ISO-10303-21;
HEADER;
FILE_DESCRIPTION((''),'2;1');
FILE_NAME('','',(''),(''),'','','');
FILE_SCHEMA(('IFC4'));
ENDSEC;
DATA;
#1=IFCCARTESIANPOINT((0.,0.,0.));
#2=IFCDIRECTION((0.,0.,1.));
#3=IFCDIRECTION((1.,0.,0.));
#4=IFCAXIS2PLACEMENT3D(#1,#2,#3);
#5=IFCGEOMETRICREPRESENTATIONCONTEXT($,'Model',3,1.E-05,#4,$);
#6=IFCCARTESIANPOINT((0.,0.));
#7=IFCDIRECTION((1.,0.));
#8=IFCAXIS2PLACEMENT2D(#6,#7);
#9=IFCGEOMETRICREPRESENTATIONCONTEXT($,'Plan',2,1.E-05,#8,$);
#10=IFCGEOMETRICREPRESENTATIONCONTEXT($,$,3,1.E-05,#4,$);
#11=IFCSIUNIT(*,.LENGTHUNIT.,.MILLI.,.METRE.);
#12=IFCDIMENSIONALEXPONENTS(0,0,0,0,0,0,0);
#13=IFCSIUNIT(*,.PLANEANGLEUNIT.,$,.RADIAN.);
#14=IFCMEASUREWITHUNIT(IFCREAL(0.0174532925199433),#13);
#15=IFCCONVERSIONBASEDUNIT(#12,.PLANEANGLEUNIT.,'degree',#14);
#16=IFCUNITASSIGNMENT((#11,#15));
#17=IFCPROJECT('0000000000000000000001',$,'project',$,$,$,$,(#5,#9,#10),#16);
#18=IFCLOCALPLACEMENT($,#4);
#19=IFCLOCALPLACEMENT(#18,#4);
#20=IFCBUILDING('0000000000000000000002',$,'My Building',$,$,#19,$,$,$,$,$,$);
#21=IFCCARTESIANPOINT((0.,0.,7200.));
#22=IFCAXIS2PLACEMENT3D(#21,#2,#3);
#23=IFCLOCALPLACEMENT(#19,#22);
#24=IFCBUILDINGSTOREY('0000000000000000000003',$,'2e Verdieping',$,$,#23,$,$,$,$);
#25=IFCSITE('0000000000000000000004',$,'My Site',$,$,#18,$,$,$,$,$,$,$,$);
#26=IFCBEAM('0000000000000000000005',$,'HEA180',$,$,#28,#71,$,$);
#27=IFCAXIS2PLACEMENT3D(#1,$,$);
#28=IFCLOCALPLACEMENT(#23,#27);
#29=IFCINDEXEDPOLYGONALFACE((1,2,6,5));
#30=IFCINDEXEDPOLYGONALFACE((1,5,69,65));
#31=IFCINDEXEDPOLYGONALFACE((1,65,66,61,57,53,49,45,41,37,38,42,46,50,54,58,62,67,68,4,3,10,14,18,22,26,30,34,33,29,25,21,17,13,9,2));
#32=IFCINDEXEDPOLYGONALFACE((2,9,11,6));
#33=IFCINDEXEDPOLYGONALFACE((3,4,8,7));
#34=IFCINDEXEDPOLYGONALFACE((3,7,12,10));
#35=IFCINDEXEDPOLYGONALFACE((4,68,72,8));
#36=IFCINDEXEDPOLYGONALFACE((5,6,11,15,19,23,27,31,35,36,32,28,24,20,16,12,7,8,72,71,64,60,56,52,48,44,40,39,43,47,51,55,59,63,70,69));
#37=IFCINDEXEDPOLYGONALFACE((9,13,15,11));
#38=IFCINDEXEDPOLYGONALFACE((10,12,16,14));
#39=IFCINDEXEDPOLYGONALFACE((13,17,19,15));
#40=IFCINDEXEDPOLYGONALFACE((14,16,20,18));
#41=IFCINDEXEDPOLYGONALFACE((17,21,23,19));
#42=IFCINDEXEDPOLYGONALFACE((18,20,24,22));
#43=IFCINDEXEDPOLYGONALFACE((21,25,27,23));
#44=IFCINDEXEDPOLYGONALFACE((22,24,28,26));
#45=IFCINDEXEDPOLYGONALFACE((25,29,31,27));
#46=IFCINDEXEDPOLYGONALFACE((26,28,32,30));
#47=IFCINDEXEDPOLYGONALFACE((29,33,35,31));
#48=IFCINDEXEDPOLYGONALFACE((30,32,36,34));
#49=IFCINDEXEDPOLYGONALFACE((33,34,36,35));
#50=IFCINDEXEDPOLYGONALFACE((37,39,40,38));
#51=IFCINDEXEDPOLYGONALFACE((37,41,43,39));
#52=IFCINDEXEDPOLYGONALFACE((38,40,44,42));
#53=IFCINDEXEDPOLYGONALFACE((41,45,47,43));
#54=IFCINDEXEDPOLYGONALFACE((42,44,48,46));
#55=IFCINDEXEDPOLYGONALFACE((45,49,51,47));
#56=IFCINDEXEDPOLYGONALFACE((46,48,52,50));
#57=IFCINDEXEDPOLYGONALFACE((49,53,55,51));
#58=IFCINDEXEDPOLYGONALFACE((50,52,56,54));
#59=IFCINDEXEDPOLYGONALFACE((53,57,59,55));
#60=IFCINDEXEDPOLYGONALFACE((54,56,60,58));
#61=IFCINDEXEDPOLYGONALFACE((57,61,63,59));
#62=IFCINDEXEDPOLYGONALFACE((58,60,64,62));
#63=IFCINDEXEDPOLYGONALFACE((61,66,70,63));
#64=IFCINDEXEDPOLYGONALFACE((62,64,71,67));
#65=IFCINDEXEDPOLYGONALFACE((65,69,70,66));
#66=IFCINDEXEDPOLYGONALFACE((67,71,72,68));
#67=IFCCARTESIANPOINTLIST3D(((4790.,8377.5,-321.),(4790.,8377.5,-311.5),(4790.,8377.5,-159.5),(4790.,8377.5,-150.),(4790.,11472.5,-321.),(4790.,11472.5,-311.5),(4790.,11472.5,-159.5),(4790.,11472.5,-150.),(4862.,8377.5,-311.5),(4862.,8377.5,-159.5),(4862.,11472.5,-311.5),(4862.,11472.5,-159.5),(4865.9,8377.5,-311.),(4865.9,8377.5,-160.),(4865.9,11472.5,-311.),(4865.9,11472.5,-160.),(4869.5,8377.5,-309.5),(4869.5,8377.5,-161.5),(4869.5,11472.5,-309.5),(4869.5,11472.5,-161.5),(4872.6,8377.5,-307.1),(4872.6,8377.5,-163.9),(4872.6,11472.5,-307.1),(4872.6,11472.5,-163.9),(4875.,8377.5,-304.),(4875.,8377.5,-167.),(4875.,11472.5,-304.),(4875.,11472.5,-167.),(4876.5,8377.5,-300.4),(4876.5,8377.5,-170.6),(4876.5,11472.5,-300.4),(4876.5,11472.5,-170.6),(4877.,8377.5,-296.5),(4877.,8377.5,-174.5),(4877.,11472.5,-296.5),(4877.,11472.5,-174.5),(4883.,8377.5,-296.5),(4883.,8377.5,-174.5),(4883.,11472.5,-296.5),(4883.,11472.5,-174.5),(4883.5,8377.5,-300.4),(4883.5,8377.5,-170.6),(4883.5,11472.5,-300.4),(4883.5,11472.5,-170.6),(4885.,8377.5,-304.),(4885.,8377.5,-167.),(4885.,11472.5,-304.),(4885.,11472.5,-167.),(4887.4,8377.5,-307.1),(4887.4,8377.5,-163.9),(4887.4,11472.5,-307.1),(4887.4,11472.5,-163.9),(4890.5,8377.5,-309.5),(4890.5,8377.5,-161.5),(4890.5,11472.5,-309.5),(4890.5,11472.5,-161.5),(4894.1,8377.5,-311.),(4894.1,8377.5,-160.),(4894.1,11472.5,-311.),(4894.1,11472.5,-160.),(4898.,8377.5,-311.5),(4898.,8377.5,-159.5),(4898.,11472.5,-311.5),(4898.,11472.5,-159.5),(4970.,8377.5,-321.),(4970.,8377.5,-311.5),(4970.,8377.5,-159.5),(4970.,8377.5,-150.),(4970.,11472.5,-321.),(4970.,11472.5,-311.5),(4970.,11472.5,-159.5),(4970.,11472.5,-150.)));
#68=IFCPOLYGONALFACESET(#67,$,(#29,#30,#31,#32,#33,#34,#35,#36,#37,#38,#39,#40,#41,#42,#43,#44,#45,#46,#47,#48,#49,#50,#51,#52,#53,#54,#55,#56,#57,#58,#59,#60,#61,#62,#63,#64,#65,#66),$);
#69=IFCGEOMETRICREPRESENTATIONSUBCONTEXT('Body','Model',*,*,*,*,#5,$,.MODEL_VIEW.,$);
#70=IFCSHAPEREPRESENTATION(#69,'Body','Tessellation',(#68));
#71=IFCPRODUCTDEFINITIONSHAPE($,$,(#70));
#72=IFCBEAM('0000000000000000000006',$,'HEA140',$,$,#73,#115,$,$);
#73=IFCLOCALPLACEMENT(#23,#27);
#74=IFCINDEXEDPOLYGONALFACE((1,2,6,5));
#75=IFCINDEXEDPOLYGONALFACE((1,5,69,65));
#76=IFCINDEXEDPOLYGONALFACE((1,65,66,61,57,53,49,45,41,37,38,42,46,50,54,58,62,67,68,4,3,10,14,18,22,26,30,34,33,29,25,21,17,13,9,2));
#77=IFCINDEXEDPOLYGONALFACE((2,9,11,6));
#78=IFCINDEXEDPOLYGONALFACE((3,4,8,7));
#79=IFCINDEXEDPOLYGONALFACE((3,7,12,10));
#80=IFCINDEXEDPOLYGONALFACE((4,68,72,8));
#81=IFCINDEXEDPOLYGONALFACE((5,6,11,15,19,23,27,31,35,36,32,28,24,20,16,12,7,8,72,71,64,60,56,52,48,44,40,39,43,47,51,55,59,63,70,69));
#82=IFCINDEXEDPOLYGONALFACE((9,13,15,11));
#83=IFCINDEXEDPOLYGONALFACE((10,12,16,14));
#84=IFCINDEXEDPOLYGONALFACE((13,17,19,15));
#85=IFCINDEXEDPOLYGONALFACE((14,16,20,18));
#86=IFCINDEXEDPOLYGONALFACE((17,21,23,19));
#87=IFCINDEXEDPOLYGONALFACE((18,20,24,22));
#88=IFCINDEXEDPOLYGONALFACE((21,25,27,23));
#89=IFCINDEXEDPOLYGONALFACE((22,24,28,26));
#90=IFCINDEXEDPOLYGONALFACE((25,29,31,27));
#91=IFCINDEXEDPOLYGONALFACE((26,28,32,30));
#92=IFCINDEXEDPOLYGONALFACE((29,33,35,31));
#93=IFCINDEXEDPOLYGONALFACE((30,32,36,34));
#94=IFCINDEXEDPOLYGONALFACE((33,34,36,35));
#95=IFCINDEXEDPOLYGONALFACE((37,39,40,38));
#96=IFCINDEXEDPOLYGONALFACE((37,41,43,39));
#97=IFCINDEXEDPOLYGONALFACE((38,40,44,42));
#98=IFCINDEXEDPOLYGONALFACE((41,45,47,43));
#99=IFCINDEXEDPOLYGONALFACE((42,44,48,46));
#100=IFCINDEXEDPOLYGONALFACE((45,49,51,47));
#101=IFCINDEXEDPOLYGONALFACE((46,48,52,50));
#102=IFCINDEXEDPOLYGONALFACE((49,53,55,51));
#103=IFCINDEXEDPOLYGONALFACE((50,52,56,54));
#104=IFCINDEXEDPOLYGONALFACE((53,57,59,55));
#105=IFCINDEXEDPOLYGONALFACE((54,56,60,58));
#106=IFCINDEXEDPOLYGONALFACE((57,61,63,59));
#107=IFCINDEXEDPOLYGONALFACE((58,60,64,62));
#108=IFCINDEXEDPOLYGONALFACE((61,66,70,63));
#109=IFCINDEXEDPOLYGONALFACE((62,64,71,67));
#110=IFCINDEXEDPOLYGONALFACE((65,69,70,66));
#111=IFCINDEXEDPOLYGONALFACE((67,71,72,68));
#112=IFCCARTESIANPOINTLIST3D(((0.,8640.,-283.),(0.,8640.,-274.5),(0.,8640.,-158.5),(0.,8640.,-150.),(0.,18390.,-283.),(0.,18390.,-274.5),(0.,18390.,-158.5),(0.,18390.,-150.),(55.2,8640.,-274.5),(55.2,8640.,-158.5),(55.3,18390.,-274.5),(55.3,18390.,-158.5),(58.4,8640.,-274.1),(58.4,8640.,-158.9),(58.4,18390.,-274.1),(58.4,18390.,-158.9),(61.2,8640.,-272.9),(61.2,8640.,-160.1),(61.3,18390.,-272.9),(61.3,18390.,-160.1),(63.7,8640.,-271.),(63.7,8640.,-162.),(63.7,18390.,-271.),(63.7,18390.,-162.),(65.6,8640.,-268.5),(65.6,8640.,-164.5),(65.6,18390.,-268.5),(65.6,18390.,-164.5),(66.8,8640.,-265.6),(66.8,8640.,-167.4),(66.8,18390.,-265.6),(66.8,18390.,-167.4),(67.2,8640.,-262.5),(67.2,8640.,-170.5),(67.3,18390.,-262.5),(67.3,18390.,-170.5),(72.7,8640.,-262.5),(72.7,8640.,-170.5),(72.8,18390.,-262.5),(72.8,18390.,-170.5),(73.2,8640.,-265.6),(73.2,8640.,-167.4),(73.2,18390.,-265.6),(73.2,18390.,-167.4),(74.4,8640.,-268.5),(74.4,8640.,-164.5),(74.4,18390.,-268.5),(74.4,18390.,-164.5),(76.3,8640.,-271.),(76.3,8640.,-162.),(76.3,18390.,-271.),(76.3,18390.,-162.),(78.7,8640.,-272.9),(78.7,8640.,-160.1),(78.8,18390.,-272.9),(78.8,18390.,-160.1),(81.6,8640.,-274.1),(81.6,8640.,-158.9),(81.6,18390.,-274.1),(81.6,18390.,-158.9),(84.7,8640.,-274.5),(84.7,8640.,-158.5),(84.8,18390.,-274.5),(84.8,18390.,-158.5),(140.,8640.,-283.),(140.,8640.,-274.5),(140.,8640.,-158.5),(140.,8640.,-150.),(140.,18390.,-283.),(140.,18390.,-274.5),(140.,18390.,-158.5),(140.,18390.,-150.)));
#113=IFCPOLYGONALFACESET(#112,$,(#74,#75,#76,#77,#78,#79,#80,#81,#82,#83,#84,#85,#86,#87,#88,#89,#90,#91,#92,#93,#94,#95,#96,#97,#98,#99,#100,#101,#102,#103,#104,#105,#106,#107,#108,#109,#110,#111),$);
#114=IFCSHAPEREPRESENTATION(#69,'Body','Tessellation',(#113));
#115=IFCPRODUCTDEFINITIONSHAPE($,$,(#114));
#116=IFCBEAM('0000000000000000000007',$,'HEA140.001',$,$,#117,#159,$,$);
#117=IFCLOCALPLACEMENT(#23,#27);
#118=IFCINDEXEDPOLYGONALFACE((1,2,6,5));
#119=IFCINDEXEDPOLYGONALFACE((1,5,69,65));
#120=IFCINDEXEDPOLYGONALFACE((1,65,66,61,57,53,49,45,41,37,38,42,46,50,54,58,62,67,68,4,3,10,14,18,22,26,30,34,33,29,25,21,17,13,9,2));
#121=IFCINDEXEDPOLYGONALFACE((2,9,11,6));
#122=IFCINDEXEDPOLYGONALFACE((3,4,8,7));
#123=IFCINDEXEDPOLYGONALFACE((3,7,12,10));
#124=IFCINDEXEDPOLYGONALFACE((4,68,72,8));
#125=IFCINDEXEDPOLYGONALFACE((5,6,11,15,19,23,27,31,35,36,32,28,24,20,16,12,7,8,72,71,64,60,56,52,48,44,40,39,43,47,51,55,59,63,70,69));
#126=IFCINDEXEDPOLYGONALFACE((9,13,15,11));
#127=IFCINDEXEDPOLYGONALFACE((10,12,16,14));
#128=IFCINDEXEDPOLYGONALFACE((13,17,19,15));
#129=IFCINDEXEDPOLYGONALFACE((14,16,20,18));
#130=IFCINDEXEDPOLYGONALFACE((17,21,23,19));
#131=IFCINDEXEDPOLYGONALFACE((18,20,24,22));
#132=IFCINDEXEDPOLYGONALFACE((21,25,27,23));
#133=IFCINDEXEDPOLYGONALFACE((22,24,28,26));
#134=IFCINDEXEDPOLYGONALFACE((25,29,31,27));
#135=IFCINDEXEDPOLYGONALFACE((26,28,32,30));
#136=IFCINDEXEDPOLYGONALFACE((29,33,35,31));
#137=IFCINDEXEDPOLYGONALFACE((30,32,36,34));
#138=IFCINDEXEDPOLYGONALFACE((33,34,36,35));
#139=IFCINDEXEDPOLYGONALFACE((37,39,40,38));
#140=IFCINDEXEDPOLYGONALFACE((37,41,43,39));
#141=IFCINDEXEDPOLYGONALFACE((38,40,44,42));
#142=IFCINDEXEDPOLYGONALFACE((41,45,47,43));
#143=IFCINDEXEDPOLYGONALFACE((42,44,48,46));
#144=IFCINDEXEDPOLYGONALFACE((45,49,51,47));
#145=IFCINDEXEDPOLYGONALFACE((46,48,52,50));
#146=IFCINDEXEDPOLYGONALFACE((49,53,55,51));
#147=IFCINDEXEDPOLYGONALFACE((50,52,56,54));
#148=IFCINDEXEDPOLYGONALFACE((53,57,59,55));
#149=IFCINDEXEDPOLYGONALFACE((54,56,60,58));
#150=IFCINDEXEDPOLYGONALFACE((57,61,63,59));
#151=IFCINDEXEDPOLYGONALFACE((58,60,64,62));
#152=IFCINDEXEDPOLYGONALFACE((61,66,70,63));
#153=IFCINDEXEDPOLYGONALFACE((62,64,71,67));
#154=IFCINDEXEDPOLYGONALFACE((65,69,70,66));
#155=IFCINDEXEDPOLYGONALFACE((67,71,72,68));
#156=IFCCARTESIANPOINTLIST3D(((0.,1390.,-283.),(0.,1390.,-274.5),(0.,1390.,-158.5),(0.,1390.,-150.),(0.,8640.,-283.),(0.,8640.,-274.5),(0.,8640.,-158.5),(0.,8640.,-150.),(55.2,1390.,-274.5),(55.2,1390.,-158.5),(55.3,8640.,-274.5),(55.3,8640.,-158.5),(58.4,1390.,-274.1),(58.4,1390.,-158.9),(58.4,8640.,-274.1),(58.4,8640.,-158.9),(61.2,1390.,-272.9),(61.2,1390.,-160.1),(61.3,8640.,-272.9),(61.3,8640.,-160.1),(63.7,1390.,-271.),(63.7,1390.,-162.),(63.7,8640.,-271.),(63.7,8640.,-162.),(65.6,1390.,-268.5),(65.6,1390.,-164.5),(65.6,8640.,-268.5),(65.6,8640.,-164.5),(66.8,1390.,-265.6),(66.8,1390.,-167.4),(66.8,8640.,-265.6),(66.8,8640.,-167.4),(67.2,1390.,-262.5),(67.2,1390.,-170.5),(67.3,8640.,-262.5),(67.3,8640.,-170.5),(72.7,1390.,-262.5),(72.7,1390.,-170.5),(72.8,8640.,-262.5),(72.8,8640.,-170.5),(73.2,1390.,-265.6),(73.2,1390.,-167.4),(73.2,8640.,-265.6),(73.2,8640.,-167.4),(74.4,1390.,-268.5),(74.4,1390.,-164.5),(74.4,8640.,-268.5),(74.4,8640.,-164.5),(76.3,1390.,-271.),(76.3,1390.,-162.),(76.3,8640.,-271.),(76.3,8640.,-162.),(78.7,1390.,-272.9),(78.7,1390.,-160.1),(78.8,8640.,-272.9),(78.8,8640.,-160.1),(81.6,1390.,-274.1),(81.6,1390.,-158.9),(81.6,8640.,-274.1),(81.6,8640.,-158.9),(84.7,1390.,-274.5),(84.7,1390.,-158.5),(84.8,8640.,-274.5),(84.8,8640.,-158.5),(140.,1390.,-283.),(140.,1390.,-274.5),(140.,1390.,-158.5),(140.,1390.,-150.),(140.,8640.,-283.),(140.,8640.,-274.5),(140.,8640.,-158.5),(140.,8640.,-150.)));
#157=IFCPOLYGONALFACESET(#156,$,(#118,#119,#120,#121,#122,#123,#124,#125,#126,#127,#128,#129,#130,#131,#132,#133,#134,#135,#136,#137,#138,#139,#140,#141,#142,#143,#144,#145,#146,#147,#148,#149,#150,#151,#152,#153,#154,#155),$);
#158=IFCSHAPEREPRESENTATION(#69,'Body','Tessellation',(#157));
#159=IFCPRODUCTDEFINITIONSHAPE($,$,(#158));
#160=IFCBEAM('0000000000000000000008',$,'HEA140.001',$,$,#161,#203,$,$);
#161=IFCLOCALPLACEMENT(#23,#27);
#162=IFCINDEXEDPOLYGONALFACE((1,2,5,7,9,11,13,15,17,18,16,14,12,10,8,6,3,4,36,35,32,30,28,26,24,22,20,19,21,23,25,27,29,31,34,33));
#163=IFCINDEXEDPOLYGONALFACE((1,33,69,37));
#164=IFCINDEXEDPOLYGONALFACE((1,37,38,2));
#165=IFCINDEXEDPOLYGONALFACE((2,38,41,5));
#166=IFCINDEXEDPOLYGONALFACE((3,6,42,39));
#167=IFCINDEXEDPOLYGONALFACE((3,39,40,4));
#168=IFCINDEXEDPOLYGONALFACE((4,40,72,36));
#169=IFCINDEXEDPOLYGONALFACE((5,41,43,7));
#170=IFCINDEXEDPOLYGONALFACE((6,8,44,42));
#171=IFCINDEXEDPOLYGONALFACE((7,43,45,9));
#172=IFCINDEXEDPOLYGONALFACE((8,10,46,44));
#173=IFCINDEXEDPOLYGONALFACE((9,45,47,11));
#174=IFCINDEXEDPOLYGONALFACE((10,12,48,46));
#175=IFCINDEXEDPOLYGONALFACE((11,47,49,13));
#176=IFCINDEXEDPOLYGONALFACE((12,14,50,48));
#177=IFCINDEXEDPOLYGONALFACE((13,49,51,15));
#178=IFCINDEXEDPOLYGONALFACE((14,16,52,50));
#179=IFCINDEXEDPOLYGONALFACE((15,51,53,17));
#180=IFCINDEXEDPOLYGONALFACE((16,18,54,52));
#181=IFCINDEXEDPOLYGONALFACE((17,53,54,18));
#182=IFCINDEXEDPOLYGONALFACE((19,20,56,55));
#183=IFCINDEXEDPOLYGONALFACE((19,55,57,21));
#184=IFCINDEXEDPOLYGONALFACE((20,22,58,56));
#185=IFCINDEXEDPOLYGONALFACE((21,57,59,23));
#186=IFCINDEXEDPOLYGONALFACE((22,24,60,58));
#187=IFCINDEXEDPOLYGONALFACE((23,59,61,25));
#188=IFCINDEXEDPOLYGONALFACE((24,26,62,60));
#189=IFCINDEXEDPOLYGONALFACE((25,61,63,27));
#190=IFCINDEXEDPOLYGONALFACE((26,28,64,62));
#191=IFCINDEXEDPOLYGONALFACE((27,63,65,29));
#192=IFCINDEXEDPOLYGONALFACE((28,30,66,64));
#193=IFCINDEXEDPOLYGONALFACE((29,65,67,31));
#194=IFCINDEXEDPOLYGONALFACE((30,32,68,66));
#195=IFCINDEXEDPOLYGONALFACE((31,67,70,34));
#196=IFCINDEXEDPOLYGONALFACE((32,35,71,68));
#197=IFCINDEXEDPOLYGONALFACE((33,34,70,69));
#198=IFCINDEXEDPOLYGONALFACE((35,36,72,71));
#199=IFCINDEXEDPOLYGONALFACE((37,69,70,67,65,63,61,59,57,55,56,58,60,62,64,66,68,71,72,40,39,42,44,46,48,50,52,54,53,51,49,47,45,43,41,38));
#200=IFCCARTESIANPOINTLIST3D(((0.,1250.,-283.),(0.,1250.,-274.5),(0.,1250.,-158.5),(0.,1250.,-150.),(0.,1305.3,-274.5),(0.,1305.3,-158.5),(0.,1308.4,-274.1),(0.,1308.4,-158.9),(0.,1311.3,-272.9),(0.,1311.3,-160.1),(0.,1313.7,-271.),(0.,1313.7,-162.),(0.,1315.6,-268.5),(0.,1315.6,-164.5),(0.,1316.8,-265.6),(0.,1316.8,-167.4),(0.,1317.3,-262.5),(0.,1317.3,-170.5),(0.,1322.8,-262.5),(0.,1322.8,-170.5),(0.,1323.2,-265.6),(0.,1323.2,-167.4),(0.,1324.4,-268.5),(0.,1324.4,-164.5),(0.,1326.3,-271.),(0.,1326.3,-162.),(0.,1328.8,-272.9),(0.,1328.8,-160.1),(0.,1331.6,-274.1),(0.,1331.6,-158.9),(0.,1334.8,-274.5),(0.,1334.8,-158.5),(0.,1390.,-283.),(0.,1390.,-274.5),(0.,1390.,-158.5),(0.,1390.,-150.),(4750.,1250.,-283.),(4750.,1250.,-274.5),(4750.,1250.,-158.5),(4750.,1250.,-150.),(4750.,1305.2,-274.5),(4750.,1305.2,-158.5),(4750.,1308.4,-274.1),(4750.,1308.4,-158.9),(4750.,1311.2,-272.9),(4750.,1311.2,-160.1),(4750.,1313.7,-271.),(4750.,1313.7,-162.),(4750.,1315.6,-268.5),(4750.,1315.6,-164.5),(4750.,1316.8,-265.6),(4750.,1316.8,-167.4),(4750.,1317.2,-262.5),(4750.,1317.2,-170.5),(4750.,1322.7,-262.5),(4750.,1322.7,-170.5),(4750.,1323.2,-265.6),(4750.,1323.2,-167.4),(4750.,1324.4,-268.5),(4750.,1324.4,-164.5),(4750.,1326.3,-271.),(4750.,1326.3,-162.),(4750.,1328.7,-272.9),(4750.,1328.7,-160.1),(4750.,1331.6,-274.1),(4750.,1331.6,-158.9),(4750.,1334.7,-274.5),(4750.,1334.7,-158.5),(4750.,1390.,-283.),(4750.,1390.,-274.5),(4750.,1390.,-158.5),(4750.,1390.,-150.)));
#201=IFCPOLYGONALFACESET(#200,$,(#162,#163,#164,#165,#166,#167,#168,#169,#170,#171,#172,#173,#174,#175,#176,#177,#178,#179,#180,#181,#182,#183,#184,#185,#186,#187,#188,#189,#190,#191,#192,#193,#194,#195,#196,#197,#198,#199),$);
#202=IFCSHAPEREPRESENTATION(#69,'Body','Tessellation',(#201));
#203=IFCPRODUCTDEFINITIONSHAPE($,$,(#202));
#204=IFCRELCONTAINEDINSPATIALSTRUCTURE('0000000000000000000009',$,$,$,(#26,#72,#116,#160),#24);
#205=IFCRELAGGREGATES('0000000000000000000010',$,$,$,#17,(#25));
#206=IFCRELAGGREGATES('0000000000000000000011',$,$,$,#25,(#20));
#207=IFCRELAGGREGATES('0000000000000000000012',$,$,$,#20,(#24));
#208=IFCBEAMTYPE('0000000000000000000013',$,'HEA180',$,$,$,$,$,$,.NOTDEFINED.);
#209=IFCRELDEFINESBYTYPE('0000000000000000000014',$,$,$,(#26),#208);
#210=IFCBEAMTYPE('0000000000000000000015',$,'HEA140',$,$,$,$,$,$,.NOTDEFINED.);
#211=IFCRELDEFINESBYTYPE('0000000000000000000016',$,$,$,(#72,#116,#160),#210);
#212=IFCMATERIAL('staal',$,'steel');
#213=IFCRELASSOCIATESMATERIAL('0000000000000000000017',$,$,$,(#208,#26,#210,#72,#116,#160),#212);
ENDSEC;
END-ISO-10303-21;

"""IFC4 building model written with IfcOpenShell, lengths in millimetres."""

from ifc_helpers import new_model, entity, si_unit, converted_unit, frame, origin_with_axes, origin_2d_with_axis, place, context, subcontext, project, spatial, i_section, extrude, material, material_profile, profile_set, profile_usage, type_object, element, save


model = new_model("IFC4")

# Units and contexts
model_context = context("Model", 3, precision=1e-05, world=origin_with_axes())
plan_context = context("Plan", 2, precision=1e-05, world=origin_2d_with_axis())
context_of_model = context(None, 3, precision=1e-05, world=origin_with_axes())
body_context = subcontext(model_context, "Body", "Model", "MODEL_VIEW")
ifc_project = project(units=[si_unit("LENGTHUNIT", "METRE", prefix="MILLI"), converted_unit("PLANEANGLEUNIT", "degree", entity("IfcReal", 0.0174532925199433), si_unit("PLANEANGLEUNIT", "RADIAN"), dimensions=[0, 0, 0, 0, 0, 0, 0])], contexts=[model_context, plan_context, context_of_model])

# Site, building, storey
site_placement = place(None, origin_with_axes())
site = spatial("IfcSite", under=ifc_project, at=site_placement, Name="My Site")
building_placement = place(site_placement, origin_with_axes())
building = spatial("IfcBuilding", under=site, at=building_placement, Name="My Building")
storey_placement = place(building_placement, frame((0.0, 0.0, 7200.0), z_axis=(0.0, 0.0, 1.0), x_axis=(1.0, 0.0, 0.0)))
storey = spatial("IfcBuildingStorey", under=building, at=storey_placement, Name="2e Verdieping")

# Beams
ifc_material_1 = material(Name="staal", Category="steel")
ifc_material_profile_1 = material_profile(ifc_material_1, i_section(OverallWidth=180.0, OverallDepth=171.0, WebThickness=6.0, FlangeThickness=9.5, FilletRadius=15.0))
ifc_profile_set_1 = profile_set([ifc_material_profile_1], Name="HEA180")
beam_type_1 = type_object("IfcBeamType", Name="HEA180", PredefinedType="NOTDEFINED", material=ifc_profile_set_1)
ifc_profile_usage_1 = profile_usage(ifc_profile_set_1)
beam_1_placement = place(storey_placement, frame((4880.0, 11472.5, -235.5), z_axis=(0.0, -1.0, 0.0), x_axis=(1.0, 0.0, 0.0)))
element("IfcBeam", 1, at=beam_1_placement, inside=storey, type_object=beam_type_1, material=ifc_profile_usage_1, Name="HEA180", context=body_context, shape_type="SweptSolid", body=[
    extrude(i_section(OverallWidth=180.0, OverallDepth=171.0, WebThickness=6.0, FlangeThickness=9.5, FilletRadius=15.0), origin_with_axes(), (0.0, 0.0, 1.0), 3095.0),
])
ifc_material_profile_2 = material_profile(ifc_material_1, i_section(OverallWidth=140.0, OverallDepth=133.0, WebThickness=5.5, FlangeThickness=8.5, FilletRadius=12.0))
ifc_profile_set_2 = profile_set([ifc_material_profile_2], Name="HEA140")
ifc_profile_usage_2 = profile_usage(ifc_profile_set_2)
beam_type_2 = type_object("IfcBeamType", Name="HEA140", PredefinedType="NOTDEFINED", material=ifc_profile_set_2)
beam_2_placement = place(storey_placement, frame((70.0, 18390.0, -216.5), z_axis=(0.0, -1.0, 0.0), x_axis=(1.0, 0.0, 0.0)))
element("IfcBeam", 2, at=beam_2_placement, inside=storey, type_object=beam_type_2, material=ifc_profile_usage_2, Name="HEA140", context=body_context, shape_type="SweptSolid", body=[
    extrude(i_section(OverallWidth=140.0, OverallDepth=133.0, WebThickness=5.5, FlangeThickness=8.5, FilletRadius=12.0), origin_with_axes(), (0.0, 0.0, 1.0), 9750.0),
])
ifc_profile_usage_3 = profile_usage(ifc_profile_set_2)
beam_3_placement = place(storey_placement, frame((70.0, 8640.0, -216.5), z_axis=(0.0, -1.0, 0.0), x_axis=(1.0, 0.0, 0.0)))
element("IfcBeam", 3, at=beam_3_placement, inside=storey, type_object=beam_type_2, material=ifc_profile_usage_3, Name="HEA140.001", context=body_context, shape_type="SweptSolid", body=[
    extrude(i_section(OverallWidth=140.0, OverallDepth=133.0, WebThickness=5.5, FlangeThickness=8.5, FilletRadius=12.0), origin_with_axes(), (0.0, 0.0, 1.0), 7250.0),
])
ifc_profile_usage_4 = profile_usage(ifc_profile_set_2)
beam_4_placement = place(storey_placement, frame((0.0, 1320.0, -216.5), z_axis=(1.0, 0.0, 0.0), x_axis=(0.0, 1.0, 0.0)))
element("IfcBeam", 4, at=beam_4_placement, inside=storey, type_object=beam_type_2, material=ifc_profile_usage_4, Name="HEA140.001", context=body_context, shape_type="SweptSolid", body=[
    extrude(i_section(OverallWidth=140.0, OverallDepth=133.0, WebThickness=5.5, FlangeThickness=8.5, FilletRadius=12.0), origin_with_axes(), (0.0, 0.0, 1.0), 4750.0),
])

save(model, "model.ifc")
